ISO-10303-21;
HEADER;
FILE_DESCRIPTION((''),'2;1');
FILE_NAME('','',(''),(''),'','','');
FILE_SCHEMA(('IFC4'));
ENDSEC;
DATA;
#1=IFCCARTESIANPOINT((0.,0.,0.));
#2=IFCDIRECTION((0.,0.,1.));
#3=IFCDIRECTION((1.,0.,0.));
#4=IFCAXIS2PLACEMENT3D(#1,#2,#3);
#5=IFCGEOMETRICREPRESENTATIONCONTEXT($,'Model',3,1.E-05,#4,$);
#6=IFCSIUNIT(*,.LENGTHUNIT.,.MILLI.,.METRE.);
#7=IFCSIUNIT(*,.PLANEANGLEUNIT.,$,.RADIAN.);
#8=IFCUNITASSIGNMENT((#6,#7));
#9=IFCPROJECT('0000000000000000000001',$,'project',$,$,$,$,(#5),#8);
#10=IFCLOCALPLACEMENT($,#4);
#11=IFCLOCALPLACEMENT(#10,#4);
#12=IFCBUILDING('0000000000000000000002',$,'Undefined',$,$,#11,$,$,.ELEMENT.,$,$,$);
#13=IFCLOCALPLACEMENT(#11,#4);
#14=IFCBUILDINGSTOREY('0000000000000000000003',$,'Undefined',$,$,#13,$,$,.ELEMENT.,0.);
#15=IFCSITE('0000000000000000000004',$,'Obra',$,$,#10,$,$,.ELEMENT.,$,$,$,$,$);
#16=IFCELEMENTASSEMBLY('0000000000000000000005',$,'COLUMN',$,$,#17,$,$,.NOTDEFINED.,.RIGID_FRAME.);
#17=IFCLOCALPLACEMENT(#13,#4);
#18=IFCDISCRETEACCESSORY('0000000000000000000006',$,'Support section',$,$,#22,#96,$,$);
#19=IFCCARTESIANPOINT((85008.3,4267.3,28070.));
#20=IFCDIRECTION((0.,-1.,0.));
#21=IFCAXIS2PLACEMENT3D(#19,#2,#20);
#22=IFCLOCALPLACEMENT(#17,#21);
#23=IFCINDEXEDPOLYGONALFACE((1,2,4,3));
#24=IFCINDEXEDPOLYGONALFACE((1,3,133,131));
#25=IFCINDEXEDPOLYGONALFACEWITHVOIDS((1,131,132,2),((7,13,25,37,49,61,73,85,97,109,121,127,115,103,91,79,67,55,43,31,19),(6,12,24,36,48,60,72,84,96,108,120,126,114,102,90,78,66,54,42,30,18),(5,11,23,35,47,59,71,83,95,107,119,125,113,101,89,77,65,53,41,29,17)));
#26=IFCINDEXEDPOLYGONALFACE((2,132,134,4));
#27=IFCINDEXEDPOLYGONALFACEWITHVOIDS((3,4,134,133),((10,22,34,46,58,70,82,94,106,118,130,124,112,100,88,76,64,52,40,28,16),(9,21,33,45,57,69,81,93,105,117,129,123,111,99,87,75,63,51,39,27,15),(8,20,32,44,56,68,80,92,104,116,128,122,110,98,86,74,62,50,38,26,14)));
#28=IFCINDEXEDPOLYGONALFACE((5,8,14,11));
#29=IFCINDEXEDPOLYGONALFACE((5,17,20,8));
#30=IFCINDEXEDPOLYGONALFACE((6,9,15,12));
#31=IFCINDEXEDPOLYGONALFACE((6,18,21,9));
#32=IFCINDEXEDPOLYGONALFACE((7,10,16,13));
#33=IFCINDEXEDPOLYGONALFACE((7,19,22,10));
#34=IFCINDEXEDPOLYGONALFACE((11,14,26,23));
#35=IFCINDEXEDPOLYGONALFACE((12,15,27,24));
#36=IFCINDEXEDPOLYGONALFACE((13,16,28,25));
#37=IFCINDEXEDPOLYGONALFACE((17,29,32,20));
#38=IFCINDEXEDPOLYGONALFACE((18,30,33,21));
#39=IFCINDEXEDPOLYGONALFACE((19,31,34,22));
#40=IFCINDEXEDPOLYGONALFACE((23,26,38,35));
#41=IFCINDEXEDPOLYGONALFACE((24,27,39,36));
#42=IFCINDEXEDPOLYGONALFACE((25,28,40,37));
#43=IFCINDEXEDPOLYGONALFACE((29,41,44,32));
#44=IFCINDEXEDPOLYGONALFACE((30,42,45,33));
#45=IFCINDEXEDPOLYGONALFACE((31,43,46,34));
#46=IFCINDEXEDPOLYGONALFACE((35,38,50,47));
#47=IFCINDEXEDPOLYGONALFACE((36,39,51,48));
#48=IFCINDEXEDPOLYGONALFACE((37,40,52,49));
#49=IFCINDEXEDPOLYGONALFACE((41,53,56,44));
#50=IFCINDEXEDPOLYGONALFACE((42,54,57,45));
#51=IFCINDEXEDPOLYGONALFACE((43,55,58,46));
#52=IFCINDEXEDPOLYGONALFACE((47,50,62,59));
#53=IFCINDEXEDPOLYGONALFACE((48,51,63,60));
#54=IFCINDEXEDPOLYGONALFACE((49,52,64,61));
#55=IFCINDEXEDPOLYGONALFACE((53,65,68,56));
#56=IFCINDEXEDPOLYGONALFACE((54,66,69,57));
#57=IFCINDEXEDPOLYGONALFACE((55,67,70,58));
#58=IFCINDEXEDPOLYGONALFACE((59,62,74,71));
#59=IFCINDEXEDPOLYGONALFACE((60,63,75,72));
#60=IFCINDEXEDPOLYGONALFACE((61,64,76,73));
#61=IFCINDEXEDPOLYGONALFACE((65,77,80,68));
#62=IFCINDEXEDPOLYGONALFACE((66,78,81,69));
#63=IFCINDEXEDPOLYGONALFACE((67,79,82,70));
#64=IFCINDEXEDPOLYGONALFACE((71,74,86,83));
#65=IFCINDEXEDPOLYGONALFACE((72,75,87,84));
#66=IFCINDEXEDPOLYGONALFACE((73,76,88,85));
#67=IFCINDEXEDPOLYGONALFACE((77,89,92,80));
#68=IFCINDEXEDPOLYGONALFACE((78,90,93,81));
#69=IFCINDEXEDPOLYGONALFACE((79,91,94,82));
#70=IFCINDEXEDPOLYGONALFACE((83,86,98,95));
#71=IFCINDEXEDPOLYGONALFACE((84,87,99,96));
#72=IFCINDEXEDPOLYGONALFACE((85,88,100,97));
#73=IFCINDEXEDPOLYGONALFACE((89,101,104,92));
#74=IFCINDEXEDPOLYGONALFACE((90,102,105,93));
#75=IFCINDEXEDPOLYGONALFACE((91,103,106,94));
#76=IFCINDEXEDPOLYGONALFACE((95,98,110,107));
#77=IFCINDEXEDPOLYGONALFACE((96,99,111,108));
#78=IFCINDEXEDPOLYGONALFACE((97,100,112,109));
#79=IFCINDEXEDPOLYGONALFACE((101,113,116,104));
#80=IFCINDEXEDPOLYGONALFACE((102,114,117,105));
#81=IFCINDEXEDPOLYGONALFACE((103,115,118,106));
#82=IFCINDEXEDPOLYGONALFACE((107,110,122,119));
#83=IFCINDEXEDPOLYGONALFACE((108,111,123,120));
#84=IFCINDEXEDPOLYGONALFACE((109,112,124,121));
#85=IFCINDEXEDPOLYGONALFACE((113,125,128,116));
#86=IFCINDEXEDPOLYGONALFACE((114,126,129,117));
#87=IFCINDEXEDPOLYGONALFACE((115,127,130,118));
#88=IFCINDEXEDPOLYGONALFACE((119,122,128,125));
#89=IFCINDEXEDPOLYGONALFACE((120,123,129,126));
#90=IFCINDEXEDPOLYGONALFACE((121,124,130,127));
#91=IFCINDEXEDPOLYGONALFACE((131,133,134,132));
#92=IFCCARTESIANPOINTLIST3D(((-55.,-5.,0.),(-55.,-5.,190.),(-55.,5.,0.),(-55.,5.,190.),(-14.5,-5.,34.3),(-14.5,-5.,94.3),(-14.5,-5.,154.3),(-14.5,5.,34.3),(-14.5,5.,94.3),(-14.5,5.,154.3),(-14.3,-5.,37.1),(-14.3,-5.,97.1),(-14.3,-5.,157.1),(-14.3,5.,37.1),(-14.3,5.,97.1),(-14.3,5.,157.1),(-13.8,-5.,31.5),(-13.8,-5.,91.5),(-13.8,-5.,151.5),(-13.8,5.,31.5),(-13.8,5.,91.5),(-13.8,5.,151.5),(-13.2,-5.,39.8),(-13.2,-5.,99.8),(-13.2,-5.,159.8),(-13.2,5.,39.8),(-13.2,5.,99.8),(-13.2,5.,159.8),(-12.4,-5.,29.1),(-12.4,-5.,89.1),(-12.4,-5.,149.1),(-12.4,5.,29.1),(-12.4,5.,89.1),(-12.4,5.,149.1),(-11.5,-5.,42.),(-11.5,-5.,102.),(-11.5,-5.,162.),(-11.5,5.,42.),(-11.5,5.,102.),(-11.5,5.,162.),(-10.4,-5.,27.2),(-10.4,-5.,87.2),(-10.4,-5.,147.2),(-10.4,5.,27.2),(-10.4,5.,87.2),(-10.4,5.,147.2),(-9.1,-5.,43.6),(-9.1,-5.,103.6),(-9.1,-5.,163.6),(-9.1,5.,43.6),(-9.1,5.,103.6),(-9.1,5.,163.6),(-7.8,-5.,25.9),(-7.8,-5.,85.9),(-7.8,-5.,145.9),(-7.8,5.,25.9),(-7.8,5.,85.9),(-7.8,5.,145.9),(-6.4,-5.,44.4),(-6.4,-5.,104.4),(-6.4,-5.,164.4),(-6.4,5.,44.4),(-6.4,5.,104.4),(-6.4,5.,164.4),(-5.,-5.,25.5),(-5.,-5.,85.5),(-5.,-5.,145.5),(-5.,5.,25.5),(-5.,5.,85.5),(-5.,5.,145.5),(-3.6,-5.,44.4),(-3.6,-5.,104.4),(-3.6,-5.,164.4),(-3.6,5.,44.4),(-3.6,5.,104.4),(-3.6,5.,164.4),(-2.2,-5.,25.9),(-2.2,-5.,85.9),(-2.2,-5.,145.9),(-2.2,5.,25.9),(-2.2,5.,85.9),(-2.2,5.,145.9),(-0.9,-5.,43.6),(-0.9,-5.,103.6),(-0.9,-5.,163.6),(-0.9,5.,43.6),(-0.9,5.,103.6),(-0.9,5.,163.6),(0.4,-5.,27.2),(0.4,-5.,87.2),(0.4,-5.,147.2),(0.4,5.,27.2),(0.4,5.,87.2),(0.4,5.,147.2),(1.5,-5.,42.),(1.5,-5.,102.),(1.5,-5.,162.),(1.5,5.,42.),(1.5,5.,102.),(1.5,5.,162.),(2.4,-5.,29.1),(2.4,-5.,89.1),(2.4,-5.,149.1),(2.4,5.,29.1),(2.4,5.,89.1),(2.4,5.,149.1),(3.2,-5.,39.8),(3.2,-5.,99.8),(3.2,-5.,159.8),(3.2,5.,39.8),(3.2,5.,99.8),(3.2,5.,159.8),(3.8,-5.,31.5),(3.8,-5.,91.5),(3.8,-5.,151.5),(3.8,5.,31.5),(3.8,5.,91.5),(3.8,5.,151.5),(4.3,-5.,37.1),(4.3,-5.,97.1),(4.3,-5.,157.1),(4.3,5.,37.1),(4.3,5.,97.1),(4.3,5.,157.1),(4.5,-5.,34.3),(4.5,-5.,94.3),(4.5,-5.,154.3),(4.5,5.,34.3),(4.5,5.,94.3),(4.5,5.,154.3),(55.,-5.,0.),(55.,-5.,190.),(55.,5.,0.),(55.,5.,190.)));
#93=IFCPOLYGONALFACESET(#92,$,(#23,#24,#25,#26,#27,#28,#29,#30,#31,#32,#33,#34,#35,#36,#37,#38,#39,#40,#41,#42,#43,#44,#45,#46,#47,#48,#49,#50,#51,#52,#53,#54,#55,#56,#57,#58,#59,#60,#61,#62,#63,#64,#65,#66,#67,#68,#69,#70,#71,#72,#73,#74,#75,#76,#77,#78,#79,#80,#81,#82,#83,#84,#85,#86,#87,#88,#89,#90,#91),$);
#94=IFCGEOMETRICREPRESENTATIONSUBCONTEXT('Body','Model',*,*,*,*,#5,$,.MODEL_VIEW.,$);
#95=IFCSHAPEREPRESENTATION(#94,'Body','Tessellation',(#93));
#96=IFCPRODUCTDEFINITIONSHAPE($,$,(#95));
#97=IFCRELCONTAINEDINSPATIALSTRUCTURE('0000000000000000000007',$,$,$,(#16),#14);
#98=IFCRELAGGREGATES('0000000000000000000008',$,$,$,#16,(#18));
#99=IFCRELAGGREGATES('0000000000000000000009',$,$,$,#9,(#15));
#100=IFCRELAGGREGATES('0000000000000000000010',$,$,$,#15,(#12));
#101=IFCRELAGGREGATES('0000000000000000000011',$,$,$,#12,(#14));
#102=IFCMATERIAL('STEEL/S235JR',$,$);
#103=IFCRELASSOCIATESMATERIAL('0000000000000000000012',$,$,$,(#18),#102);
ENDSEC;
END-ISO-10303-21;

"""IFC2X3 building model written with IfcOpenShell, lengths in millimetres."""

from ifc_helpers import new_model, si_unit, frame, origin_with_axes, origin_2d_with_axis, place, context, subcontext, project, spatial, rectangle, circle, extrude, source, transform, mapped, material, element, aggregate, save


model = new_model("IFC2X3")

# Units and contexts
model_context = context("Model", 3, precision=1e-05, world=origin_with_axes())
body_context = subcontext(model_context, "Body", "Model", "MODEL_VIEW")
ifc_project = project(units=[si_unit("LENGTHUNIT", "METRE", prefix="MILLI"), si_unit("PLANEANGLEUNIT", "RADIAN")], contexts=[model_context])

# Site, building, storey
site_placement = place(None, origin_with_axes())
site = spatial("IfcSite", under=ifc_project, at=site_placement, Name="Obra", CompositionType="ELEMENT")
building_placement = place(site_placement, origin_with_axes())
building = spatial("IfcBuilding", under=site, at=building_placement, Name="Undefined", CompositionType="ELEMENT")
storey_placement = place(building_placement, origin_with_axes())
storey = spatial("IfcBuildingStorey", under=building, at=storey_placement, Name="Undefined", CompositionType="ELEMENT", Elevation=0.0)

# Shared definitions
ifc_material = material(Name="STEEL/S235JR")

# Element assembly, discrete accessory, opening
assembly_1_placement = place(storey_placement, origin_with_axes())
assembly_1 = element("IfcElementAssembly", 1, at=assembly_1_placement, inside=storey, Name="COLUMN", AssemblyPlace="NOTDEFINED", PredefinedType="RIGID_FRAME")
discrete_accessory_1_placement = place(assembly_1_placement, frame((85008.3, 4267.3, 28070.0), z_axis=(0.0, 0.0, 1.0), x_axis=(0.0, -1.0, 0.0)))
discrete_accessory_1 = element("IfcDiscreteAccessory", 2, at=discrete_accessory_1_placement, material=ifc_material, Name="Support section", context=body_context, shape_type="SweptSolid", body=[
    extrude(rectangle(XDim=10.0, YDim=110.0, at=origin_2d_with_axis()), frame((0.0, 0.0, 190.0), z_axis=(0.0, 0.0, -1.0), x_axis=(0.0, 1.0, 0.0)), (0.0, 0.0, 1.0), 190.0),
])
shared_shape_1 = source(origin_with_axes(), body_context, "Body", "SweptSolid", [
    extrude(circle(Radius=9.5, at=origin_2d_with_axis()), frame((0.0, -13.4, 0.0), z_axis=(0.0, 1.0, 0.0), x_axis=(1.0, 0.0, 0.0)), (0.0, 0.0, 1.0), 10.2),
])
opening_1_placement = place(assembly_1_placement, frame((85000.0, 4222.3, 28300.0), z_axis=(0.0, 1.0, 0.0), x_axis=(0.0, 0.0, -1.0)))
element("IfcOpeningElement", 3, at=opening_1_placement, cuts=discrete_accessory_1, ObjectType="Opening", context=body_context, shape_type="MappedRepresentation", body=[
    mapped(shared_shape_1, transform((75.0, 0.0, 50.0))),
    mapped(shared_shape_1, transform((135.0, 0.0, 50.0))),
    mapped(shared_shape_1, transform((195.0, 0.0, 50.0))),
])
aggregate(assembly_1, [discrete_accessory_1])

save(model, "model.ifc")
